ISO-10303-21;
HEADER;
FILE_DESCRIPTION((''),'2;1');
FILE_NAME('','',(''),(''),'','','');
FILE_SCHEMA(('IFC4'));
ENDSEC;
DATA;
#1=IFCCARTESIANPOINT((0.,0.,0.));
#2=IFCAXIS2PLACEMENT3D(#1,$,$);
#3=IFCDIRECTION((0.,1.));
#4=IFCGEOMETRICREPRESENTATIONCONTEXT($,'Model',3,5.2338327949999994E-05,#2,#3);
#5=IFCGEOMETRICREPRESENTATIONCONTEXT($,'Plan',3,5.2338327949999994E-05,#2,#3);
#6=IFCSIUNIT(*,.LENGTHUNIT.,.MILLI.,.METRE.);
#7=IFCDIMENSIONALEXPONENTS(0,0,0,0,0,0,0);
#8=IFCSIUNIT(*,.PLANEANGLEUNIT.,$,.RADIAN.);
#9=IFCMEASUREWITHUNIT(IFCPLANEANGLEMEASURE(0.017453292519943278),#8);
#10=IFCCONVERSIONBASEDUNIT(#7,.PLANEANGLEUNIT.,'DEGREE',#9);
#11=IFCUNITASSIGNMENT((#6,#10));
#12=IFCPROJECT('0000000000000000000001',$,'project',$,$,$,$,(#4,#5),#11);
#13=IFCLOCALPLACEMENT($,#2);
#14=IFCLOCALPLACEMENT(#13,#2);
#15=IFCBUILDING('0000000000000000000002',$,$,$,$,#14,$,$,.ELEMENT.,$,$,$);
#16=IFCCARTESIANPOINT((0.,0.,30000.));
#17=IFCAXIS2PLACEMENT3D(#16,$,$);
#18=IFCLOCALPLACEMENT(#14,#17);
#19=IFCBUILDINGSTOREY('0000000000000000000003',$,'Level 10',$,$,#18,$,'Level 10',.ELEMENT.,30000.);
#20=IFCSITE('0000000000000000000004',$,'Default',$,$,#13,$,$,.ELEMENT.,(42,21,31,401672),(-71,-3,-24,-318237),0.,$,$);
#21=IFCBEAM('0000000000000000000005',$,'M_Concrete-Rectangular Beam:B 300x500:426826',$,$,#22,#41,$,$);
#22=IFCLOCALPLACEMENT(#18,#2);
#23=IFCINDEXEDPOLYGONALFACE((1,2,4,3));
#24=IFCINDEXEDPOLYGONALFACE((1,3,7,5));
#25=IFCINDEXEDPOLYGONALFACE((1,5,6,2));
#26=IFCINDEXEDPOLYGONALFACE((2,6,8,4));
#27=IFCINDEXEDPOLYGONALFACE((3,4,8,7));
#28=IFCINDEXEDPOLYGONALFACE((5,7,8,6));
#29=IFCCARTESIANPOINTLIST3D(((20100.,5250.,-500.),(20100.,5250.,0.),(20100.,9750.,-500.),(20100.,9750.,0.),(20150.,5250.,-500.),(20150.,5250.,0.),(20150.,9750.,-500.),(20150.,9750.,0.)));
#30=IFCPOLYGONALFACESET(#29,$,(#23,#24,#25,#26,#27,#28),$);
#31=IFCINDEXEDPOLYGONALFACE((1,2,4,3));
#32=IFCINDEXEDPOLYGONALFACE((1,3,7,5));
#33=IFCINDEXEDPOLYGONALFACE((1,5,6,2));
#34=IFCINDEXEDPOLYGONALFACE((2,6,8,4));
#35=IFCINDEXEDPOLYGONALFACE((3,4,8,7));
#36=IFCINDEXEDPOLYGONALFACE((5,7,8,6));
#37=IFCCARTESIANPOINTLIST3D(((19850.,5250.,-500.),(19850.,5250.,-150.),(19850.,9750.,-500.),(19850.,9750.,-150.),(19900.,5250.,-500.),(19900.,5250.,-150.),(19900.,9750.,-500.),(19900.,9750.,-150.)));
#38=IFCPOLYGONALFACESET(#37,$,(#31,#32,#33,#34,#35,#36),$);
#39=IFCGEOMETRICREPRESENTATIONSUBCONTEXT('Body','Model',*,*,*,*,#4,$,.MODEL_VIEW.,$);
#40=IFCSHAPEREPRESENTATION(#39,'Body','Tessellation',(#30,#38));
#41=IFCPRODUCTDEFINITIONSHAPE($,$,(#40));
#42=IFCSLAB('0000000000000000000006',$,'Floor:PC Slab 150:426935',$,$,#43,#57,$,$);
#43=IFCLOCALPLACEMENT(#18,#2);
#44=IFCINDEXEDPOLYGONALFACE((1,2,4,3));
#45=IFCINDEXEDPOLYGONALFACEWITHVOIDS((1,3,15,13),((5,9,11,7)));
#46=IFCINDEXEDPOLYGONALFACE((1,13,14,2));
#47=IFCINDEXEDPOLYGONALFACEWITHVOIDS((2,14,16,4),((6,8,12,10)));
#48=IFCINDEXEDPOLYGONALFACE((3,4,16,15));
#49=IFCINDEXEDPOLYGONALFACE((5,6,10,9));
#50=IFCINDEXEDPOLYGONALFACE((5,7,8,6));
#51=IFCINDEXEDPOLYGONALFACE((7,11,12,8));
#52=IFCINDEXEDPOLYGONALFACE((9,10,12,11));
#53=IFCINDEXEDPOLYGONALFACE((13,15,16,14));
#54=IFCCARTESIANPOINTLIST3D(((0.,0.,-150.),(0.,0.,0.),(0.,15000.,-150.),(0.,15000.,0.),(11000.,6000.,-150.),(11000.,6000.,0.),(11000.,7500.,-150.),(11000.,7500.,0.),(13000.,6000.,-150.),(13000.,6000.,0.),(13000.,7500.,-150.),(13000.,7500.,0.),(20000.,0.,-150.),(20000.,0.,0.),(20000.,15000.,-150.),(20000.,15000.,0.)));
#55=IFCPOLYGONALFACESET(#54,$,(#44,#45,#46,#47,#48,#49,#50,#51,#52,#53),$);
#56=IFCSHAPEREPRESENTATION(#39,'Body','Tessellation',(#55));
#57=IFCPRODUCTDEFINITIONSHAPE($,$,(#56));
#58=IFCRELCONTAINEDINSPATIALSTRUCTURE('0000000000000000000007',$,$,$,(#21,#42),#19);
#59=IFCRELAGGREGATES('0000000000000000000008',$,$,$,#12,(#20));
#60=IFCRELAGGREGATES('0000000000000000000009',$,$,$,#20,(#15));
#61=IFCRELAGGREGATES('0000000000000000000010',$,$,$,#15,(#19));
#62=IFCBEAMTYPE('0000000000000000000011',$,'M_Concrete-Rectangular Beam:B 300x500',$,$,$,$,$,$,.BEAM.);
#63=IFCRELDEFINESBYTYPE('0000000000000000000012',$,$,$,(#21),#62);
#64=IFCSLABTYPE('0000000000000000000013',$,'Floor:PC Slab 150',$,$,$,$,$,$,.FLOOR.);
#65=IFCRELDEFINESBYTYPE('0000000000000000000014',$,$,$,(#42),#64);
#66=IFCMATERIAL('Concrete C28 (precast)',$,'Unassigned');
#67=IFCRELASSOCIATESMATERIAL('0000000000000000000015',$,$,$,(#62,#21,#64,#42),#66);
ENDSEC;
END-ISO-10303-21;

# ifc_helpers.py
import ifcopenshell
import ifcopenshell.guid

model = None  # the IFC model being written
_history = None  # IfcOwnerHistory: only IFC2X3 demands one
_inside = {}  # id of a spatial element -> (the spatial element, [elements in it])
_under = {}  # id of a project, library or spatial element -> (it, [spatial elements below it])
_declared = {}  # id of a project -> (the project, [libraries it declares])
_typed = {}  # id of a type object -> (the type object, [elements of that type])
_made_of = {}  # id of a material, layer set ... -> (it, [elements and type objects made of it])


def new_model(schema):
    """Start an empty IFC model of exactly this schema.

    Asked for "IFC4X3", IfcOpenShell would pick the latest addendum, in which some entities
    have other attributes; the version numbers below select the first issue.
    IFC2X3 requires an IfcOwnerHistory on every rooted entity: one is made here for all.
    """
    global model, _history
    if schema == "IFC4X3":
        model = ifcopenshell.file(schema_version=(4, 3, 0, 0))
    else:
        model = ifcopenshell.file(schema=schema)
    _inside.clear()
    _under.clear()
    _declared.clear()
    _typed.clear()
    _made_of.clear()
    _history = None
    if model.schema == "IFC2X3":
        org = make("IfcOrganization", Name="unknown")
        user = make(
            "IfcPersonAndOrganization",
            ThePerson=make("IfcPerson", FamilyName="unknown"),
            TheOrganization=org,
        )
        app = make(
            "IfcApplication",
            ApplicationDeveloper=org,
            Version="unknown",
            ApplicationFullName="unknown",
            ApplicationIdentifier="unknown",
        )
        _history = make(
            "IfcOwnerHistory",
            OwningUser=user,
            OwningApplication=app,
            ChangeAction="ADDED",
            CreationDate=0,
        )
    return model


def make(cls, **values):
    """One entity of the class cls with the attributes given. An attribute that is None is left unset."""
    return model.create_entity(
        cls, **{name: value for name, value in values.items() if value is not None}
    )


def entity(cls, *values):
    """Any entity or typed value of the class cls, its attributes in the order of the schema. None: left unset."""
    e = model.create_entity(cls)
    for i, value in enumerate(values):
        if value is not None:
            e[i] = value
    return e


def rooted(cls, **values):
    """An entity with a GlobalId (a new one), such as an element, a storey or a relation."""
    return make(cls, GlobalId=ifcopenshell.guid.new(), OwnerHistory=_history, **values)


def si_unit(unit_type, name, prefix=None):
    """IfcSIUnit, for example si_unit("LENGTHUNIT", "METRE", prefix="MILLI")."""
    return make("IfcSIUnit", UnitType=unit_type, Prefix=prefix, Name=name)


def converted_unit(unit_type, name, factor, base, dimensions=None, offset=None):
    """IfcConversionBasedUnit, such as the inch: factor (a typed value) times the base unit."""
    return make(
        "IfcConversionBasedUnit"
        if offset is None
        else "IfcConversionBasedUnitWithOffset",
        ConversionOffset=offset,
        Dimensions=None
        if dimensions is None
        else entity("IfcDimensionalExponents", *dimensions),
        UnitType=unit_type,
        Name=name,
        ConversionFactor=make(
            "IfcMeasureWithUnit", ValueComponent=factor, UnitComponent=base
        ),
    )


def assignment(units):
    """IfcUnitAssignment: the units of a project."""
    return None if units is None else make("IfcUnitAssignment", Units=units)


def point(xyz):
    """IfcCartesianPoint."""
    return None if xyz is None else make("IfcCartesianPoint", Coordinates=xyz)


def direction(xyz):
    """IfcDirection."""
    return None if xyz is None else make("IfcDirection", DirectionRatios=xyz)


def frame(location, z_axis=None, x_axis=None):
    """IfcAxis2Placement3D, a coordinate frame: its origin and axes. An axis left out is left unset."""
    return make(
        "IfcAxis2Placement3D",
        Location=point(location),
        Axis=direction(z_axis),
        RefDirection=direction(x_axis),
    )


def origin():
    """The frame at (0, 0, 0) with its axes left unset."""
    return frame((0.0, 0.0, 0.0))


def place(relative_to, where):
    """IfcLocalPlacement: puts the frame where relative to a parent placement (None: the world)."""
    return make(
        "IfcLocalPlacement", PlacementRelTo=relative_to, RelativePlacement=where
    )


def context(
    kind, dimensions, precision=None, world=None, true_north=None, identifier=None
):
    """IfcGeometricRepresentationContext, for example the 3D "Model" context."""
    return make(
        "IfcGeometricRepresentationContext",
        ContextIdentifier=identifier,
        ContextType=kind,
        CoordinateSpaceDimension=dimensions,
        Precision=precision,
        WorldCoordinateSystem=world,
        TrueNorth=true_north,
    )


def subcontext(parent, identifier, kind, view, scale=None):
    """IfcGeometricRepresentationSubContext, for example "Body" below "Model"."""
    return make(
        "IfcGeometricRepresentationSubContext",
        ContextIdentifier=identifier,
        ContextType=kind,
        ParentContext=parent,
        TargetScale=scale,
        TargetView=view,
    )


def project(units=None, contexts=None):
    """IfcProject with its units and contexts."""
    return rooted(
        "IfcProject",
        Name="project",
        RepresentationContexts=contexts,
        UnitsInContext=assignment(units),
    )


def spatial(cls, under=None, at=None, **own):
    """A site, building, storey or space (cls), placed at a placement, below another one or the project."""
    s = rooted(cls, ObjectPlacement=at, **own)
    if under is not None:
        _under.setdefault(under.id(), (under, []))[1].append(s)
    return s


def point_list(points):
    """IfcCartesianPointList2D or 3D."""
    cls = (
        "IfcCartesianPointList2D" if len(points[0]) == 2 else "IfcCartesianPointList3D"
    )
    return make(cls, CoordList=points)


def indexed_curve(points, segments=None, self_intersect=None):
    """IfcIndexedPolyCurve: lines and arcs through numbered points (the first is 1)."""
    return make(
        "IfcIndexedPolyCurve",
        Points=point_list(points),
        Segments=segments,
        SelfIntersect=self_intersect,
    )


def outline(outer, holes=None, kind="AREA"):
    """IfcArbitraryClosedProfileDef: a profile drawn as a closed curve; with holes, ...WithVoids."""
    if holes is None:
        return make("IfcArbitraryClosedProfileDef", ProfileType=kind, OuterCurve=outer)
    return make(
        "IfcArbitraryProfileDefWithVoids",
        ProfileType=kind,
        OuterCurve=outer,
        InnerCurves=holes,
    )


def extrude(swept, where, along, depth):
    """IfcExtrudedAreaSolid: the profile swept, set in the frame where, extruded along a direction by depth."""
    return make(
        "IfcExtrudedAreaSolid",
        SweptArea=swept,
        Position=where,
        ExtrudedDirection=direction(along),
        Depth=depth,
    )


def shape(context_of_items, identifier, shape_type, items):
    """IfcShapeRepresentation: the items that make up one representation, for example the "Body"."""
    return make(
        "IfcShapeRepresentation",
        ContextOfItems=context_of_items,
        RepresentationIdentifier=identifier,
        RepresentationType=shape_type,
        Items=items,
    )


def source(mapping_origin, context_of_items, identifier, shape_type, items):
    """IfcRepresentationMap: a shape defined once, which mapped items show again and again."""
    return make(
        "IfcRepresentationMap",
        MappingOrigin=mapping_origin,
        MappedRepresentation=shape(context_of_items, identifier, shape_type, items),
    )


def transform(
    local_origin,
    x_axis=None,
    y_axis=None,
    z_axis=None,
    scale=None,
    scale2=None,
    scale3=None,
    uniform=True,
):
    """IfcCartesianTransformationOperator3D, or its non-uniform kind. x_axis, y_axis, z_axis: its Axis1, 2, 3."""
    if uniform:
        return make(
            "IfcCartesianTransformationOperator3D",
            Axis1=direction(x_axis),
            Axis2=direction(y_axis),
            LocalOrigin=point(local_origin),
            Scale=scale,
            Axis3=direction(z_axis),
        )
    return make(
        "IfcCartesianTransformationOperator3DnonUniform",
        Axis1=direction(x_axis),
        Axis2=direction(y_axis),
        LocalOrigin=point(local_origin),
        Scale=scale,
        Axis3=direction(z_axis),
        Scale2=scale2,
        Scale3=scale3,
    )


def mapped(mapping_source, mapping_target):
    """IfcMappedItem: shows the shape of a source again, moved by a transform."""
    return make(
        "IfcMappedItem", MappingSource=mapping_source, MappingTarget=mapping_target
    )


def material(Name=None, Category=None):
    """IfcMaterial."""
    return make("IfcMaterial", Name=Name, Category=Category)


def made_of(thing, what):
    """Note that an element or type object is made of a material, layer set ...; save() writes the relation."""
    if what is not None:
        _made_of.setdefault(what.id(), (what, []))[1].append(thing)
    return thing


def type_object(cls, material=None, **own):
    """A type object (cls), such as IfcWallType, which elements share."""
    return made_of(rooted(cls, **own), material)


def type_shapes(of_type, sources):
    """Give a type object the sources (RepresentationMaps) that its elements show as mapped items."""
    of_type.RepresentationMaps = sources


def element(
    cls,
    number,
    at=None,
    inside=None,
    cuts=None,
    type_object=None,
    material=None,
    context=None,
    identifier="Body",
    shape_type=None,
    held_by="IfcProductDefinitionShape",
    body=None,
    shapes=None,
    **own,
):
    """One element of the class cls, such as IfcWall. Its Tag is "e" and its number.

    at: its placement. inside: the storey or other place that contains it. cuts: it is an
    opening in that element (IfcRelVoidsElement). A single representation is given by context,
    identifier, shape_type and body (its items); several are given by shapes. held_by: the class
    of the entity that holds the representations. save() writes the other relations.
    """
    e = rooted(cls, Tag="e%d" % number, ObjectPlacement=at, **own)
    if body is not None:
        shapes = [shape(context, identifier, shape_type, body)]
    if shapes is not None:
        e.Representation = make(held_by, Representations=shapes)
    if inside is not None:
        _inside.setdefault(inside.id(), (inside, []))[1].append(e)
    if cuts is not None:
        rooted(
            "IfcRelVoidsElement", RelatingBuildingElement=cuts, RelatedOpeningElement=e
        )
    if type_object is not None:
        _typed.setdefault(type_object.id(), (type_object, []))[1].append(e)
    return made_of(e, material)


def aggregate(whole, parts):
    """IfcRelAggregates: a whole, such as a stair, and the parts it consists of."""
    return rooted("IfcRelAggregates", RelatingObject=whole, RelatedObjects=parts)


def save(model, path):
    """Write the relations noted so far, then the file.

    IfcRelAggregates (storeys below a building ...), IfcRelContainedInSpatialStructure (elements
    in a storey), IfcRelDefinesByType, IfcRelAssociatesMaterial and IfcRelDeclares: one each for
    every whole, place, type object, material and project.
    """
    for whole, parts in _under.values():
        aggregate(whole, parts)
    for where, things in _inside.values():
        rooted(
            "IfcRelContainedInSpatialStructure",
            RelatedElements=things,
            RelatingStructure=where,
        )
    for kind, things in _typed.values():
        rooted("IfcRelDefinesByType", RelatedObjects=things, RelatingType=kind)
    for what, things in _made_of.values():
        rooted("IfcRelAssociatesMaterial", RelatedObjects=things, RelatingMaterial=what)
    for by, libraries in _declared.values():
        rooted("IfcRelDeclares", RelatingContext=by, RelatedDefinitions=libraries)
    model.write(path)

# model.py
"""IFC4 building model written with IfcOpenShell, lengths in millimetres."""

from ifc_helpers import new_model, entity, si_unit, converted_unit, direction, frame, origin, place, context, subcontext, project, spatial, indexed_curve, outline, extrude, source, transform, mapped, material, type_object, type_shapes, element, save


model = new_model("IFC4")

# Units and contexts
model_context = context("Model", 3, precision=5.2338327949999994e-05, world=origin(), true_north=direction((0.0, 1.0)))
plan_context = context("Plan", 3, precision=5.2338327949999994e-05, world=origin(), true_north=direction((0.0, 1.0)))
body_context = subcontext(model_context, "Body", "Model", "MODEL_VIEW")
ifc_project = project(units=[si_unit("LENGTHUNIT", "METRE", prefix="MILLI"), converted_unit("PLANEANGLEUNIT", "DEGREE", entity("IfcPlaneAngleMeasure", 0.017453292519943278), si_unit("PLANEANGLEUNIT", "RADIAN"), dimensions=[0, 0, 0, 0, 0, 0, 0])], contexts=[model_context, plan_context])

# Site, building, storey
site_placement = place(None, origin())
site = spatial("IfcSite", under=ifc_project, at=site_placement, Name="Default", CompositionType="ELEMENT", RefLatitude=(42, 21, 31, 401672), RefLongitude=(-71, -3, -24, -318237), RefElevation=0.0)
building_placement = place(site_placement, origin())
building = spatial("IfcBuilding", under=site, at=building_placement, CompositionType="ELEMENT")
storey_placement = place(building_placement, frame((0.0, 0.0, 30000.0)))
storey = spatial("IfcBuildingStorey", under=building, at=storey_placement, Name="Level 10", LongName="Level 10", CompositionType="ELEMENT", Elevation=30000.0)

# Beam
ifc_material = material(Name="Concrete C28 (precast)", Category="Unassigned")
beam_type_1 = type_object("IfcBeamType", Name="M_Concrete-Rectangular Beam:B 300x500", PredefinedType="BEAM", material=ifc_material)
shared_shape_1 = source(origin(), body_context, "Body", "SweptSolid", [
    extrude(outline(indexed_curve([(-25.0, -250.0), (25.0, -250.0), (25.0, 250.0), (-25.0, 250.0), (-25.0, -250.0)], self_intersect=False)), frame((20125.0, 5250.0, 29750.0), z_axis=(0.0, 1.0, 0.0), x_axis=(-1.0, 0.0, 0.0)), (0.0, 0.0, 1.0), 4500.0),
    extrude(outline(indexed_curve([(-25.0, -175.0), (25.0, -175.0), (25.0, 175.0), (-25.0, 175.0), (-25.0, -175.0)], self_intersect=False)), frame((19875.0, 5250.0, 29675.0), z_axis=(0.0, 1.0, 0.0), x_axis=(-1.0, 0.0, 0.0)), (0.0, 0.0, 1.0), 4500.0),
])
type_shapes(beam_type_1, [shared_shape_1])
beam_1_placement = place(storey_placement, frame((0.0, 0.0, -30000.0)))
element("IfcBeam", 1, at=beam_1_placement, inside=storey, type_object=beam_type_1, material=ifc_material, Name="M_Concrete-Rectangular Beam:B 300x500:426826", context=body_context, shape_type="MappedRepresentation", body=[
    mapped(shared_shape_1, transform((0.0, 0.0, 0.0), scale=1.0)),
])

# Slab, opening
slab_type = type_object("IfcSlabType", Name="Floor:PC Slab 150", PredefinedType="FLOOR", material=ifc_material)
slab_placement = place(storey_placement, origin())
slab = element("IfcSlab", 2, at=slab_placement, inside=storey, type_object=slab_type, material=ifc_material, Name="Floor:PC Slab 150:426935", context=body_context, shape_type="SweptSolid", body=[
    extrude(outline(indexed_curve([(-7500.0, -10000.0), (7500.0, -10000.0), (7500.0, 10000.0), (-7500.0, 10000.0), (-7500.0, -10000.0)], self_intersect=False), holes=[indexed_curve([(-1500.0, -3000.0), (-1500.0, -1000.0), (0.0, -1000.0), (0.0, -3000.0), (-1500.0, -3000.0)], self_intersect=False)]), frame((10000.0, 7500.0, -150.0), z_axis=(0.0, 0.0, 1.0), x_axis=(0.0, 1.0, 0.0)), (0.0, 0.0, 1.0), 150.0),
])
opening_placement = place(slab_placement, origin())
element("IfcOpeningElement", 3, at=opening_placement, cuts=slab, PredefinedType="OPENING", context=body_context, shape_type="SweptSolid", body=[
    extrude(outline(indexed_curve([(13000.0, 6000.0), (13000.0, 7500.0), (11000.0, 7500.0), (11000.0, 6000.0), (13000.0, 6000.0)], self_intersect=False)), frame((0.0, 0.0, -30000.0)), (0.0, 0.0, 1.0), 20000.0),
])

save(model, "model.ifc")
